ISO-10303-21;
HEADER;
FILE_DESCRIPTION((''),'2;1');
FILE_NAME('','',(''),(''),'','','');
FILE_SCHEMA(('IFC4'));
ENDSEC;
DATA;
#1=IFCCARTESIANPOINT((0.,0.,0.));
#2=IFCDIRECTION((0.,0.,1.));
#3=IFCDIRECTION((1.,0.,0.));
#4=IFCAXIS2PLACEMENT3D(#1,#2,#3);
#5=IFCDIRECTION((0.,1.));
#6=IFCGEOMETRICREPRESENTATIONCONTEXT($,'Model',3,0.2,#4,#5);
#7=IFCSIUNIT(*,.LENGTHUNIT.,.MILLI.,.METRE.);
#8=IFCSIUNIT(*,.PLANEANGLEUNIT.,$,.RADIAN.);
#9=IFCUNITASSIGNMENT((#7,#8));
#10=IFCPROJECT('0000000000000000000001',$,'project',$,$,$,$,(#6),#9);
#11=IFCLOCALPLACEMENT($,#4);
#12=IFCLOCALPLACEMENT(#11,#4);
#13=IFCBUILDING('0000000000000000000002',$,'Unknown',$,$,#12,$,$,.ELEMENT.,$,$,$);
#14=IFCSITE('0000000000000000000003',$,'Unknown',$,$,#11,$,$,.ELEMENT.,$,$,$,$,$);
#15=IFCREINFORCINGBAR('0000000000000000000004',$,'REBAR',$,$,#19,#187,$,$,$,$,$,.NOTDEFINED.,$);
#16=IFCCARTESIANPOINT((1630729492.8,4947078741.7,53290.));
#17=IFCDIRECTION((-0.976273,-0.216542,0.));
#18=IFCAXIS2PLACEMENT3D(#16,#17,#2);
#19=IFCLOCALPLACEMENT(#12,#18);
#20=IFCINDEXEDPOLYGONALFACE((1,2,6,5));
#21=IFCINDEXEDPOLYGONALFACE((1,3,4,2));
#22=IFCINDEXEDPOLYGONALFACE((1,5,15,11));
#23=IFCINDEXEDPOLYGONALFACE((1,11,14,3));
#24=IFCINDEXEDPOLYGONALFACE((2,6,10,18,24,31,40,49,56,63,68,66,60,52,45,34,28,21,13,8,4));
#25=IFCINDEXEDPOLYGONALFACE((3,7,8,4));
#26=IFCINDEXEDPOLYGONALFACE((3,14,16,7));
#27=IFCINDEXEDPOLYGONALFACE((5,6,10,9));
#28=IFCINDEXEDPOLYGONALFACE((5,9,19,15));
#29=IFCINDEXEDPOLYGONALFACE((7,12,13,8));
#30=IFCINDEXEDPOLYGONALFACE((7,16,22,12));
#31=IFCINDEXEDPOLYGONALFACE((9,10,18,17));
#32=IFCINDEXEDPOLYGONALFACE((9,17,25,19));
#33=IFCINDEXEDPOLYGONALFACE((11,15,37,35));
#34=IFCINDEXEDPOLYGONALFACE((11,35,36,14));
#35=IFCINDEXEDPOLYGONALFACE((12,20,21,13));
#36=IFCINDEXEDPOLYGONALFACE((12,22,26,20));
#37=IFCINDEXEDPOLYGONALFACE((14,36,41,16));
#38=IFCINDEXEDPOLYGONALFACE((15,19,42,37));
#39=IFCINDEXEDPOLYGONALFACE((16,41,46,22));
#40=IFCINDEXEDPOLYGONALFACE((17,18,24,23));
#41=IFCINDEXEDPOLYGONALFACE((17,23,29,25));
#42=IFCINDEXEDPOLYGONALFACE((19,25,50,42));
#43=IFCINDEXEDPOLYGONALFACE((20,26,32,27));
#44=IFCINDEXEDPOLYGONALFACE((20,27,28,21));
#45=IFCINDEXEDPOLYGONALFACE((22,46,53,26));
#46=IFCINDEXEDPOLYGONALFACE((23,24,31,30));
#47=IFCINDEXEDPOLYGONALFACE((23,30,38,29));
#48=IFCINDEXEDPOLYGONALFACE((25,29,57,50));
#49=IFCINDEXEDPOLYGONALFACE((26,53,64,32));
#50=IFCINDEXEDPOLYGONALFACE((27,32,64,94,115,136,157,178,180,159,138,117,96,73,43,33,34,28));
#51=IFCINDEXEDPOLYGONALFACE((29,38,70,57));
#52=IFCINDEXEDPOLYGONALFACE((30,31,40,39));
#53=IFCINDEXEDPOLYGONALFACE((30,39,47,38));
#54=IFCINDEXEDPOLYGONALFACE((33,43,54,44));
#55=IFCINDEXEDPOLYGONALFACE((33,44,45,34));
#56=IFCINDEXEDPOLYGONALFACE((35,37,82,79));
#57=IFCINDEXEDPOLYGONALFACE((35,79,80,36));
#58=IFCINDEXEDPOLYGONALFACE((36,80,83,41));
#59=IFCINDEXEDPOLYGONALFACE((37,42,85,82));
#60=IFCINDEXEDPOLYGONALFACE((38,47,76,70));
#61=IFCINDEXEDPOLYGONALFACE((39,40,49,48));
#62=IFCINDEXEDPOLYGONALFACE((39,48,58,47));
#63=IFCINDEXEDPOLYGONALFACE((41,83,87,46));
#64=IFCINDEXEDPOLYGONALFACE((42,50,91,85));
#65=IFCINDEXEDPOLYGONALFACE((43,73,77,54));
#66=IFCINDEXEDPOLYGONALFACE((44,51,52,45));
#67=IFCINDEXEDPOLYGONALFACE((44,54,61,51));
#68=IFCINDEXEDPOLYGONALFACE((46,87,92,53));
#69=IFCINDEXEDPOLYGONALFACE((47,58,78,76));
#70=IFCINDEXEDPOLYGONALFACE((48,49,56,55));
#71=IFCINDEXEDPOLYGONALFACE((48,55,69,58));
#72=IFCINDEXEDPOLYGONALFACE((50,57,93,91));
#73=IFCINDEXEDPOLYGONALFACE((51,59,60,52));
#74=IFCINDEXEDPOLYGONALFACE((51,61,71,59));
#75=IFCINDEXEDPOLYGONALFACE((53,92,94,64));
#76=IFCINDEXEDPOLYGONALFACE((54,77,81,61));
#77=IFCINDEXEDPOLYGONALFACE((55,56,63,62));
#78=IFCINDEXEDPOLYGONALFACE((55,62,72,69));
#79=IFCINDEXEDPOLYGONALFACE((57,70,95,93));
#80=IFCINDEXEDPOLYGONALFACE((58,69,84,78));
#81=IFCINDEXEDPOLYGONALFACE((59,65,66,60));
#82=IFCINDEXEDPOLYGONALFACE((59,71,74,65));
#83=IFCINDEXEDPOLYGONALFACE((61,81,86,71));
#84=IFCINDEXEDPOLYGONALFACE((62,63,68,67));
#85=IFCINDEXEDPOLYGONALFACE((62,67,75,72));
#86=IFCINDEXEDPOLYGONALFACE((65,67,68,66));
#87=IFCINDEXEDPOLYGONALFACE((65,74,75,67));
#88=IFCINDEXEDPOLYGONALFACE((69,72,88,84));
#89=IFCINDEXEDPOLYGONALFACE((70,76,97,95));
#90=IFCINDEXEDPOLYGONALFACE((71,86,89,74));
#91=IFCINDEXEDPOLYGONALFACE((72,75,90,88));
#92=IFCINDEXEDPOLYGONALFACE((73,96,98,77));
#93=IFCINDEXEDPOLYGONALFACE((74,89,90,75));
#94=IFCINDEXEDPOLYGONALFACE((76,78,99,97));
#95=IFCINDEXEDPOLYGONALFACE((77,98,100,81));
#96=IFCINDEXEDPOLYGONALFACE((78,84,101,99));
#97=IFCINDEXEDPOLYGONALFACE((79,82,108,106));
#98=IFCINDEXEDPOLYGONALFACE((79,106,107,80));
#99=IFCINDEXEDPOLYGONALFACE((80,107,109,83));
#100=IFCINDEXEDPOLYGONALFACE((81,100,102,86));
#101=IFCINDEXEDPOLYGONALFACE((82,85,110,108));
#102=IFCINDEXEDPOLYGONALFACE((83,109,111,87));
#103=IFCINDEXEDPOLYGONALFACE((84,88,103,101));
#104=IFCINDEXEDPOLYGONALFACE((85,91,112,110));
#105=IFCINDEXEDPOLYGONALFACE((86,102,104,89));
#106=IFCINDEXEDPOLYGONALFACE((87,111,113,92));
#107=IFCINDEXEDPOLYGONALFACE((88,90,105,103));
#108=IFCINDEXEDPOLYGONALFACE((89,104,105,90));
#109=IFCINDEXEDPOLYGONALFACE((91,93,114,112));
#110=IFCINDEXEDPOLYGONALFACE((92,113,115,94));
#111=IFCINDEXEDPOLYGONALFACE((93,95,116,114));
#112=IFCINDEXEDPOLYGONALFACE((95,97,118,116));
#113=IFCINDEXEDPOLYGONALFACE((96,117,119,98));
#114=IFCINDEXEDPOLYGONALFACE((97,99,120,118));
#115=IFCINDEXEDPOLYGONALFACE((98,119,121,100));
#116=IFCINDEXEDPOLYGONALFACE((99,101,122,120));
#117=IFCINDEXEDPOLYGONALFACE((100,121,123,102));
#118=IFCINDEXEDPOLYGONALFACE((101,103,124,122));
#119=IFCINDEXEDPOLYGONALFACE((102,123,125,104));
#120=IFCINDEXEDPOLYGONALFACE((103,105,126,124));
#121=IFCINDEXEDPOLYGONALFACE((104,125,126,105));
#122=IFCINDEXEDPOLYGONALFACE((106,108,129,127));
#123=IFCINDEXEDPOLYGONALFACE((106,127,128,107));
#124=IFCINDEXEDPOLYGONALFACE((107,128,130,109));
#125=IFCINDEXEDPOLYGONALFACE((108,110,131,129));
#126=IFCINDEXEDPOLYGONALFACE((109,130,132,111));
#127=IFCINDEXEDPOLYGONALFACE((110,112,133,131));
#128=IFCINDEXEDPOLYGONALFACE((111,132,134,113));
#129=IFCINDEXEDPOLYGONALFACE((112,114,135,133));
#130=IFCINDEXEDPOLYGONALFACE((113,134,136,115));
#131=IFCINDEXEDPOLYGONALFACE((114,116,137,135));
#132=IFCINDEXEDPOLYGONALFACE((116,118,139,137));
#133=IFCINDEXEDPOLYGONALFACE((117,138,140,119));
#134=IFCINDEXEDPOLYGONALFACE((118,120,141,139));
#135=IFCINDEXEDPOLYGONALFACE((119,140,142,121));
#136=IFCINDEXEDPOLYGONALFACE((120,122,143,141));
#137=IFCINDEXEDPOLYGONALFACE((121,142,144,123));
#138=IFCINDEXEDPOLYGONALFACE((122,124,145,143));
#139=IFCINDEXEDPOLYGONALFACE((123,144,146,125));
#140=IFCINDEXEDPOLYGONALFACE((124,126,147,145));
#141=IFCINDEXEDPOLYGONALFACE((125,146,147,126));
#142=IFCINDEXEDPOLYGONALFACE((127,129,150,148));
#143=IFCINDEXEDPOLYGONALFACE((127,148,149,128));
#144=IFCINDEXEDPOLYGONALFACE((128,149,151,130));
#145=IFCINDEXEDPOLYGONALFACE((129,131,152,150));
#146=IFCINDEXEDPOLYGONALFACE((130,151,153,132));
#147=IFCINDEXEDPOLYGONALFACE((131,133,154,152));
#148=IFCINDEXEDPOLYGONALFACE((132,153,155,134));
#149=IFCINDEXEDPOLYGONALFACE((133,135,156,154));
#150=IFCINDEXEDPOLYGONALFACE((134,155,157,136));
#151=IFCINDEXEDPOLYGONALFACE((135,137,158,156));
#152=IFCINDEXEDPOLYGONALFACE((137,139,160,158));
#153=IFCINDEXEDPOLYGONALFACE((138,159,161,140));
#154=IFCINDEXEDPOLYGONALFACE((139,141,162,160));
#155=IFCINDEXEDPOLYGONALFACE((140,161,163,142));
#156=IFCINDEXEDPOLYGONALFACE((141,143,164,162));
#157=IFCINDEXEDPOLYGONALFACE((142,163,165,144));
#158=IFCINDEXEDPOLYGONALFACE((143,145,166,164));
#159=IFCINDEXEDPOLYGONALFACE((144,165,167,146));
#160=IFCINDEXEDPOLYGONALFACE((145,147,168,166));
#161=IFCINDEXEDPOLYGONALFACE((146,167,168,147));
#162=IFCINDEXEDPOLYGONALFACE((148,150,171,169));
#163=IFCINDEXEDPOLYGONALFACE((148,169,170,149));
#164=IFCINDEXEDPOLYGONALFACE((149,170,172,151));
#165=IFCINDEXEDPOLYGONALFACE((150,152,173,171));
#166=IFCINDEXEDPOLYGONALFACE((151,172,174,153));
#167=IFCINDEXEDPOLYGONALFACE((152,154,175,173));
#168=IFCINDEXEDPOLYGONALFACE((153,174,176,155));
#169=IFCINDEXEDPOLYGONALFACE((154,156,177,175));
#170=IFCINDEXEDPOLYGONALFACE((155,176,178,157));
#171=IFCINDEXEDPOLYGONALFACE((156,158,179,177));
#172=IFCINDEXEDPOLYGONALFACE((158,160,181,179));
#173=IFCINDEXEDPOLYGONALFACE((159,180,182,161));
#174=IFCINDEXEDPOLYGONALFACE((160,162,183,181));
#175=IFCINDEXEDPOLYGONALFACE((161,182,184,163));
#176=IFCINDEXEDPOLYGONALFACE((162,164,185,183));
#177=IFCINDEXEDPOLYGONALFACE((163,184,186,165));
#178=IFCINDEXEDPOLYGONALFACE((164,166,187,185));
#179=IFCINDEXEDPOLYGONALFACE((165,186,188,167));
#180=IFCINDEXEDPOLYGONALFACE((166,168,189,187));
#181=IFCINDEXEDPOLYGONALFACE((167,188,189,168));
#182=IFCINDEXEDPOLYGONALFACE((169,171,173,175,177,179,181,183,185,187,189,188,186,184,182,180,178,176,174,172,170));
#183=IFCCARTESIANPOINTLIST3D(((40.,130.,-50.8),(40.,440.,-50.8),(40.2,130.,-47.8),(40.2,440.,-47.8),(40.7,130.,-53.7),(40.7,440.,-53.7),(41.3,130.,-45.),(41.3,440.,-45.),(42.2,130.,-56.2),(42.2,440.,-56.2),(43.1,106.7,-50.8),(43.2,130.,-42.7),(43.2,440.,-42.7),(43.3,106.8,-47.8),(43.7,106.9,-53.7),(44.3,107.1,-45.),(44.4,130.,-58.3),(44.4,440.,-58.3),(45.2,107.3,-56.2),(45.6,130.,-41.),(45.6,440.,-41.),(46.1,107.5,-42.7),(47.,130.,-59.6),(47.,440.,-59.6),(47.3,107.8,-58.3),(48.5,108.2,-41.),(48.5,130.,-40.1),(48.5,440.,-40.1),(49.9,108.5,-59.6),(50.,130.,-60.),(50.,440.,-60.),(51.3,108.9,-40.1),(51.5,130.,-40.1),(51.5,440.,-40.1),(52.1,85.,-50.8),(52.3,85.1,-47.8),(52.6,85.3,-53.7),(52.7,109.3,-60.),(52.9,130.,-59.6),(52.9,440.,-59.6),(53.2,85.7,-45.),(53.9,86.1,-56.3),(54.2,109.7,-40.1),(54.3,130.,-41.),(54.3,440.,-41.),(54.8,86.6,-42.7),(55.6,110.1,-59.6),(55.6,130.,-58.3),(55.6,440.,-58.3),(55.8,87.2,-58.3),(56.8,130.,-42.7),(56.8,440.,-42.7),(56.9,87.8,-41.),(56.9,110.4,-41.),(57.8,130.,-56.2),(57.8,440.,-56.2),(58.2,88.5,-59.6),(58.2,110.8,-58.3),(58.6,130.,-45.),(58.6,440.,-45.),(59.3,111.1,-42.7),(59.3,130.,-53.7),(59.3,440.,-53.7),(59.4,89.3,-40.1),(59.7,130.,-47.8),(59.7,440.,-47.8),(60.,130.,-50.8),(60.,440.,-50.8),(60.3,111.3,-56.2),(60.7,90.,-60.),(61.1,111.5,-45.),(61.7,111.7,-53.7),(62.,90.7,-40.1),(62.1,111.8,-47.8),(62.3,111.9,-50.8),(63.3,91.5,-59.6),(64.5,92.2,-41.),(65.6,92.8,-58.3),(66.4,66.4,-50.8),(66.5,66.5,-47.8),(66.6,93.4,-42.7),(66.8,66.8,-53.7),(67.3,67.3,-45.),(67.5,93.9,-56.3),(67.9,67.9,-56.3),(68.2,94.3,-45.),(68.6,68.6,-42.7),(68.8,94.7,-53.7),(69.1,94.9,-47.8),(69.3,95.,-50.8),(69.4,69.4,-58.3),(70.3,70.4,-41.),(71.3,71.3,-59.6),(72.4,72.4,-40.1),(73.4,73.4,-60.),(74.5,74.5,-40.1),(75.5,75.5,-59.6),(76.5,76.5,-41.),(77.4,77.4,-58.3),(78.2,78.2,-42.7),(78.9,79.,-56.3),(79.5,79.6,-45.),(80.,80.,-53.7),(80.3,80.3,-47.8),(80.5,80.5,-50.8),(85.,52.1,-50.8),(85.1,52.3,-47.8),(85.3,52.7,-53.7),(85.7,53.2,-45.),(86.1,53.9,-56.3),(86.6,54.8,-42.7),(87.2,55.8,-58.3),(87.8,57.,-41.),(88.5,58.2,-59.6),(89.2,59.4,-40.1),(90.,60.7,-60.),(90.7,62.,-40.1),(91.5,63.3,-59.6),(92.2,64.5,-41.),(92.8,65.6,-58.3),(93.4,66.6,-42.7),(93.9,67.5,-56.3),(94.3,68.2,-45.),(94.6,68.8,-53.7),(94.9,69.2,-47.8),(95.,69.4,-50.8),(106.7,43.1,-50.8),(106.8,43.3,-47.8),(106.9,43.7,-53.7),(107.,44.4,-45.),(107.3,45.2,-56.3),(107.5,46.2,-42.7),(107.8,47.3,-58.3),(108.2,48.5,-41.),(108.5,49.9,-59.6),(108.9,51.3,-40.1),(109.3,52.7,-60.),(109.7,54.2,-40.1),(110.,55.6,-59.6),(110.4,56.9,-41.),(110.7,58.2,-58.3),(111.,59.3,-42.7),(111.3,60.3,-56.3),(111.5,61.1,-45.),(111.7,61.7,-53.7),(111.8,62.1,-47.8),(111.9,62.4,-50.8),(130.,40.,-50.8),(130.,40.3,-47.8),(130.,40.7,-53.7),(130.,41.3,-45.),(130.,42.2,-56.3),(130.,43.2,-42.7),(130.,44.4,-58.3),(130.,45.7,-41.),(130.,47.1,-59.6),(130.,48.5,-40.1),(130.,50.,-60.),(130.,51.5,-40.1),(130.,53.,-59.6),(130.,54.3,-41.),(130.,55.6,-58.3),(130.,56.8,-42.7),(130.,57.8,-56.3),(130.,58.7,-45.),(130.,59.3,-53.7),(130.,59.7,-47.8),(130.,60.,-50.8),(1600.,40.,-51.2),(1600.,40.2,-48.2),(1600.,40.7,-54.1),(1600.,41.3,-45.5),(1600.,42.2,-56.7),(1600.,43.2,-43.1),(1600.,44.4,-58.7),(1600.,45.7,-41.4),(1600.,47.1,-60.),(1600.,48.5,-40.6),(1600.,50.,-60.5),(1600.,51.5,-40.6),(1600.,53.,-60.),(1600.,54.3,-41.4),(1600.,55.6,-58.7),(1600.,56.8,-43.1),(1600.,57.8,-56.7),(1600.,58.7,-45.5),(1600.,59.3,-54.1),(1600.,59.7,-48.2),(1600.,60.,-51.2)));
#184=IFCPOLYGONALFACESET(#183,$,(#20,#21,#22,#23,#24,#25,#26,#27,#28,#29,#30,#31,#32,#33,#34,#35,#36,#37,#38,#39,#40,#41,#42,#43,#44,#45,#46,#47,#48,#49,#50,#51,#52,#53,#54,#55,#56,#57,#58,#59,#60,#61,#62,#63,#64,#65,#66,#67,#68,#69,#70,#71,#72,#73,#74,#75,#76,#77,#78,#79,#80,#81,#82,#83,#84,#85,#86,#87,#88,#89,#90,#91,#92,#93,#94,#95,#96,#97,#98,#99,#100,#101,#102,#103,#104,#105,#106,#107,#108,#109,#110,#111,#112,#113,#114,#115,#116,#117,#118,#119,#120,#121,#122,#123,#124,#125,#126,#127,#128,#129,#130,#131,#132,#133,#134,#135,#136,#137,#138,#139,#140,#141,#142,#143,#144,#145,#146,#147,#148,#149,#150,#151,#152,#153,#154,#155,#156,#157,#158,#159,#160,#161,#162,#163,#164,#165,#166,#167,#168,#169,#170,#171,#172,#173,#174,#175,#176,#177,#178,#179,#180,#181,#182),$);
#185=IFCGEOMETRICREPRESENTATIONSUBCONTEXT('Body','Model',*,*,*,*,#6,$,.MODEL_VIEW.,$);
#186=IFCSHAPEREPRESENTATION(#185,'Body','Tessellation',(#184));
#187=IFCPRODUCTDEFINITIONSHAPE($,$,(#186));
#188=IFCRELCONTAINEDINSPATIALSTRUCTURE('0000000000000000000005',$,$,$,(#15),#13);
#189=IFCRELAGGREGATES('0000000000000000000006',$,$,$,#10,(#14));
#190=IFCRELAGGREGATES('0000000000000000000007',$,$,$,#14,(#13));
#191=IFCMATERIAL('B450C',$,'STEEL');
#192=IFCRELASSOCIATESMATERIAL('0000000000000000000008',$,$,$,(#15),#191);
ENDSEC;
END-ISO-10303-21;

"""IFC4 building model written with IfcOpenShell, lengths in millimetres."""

from ifc_helpers import new_model, entity, si_unit, direction, frame, origin_with_axes, place, context, subcontext, project, spatial, material, element, save


model = new_model("IFC4")

# Units and contexts
model_context = context("Model", 3, precision=0.2, world=origin_with_axes(), true_north=direction((0.0, 1.0)))
body_context = subcontext(model_context, "Body", "Model", "MODEL_VIEW")
ifc_project = project(units=[si_unit("LENGTHUNIT", "METRE", prefix="MILLI"), si_unit("PLANEANGLEUNIT", "RADIAN")], contexts=[model_context])

# Site, building
site_placement = place(None, origin_with_axes())
site = spatial("IfcSite", under=ifc_project, at=site_placement, Name="Unknown", CompositionType="ELEMENT")
building_placement = place(site_placement, origin_with_axes())
building = spatial("IfcBuilding", under=site, at=building_placement, Name="Unknown", CompositionType="ELEMENT")

# Reinforcing bar
ifc_material = material(Name="B450C", Category="STEEL")
reinforcing_bar_1_placement = place(building_placement, frame((1630729492.8, 4947078741.7, 53290.0), z_axis=(-0.976273, -0.216542, 0.0), x_axis=(0.0, 0.0, 1.0)))
element("IfcReinforcingBar", 1, at=reinforcing_bar_1_placement, inside=building, material=ifc_material, Name="REBAR", PredefinedType="NOTDEFINED", context=body_context, shape_type="AdvancedSweptSolid", body=[
    entity("IfcSweptDiskSolid", entity("IfcIndexedPolyCurve", entity("IfcCartesianPointList3D", [[50.0, 440.0, -50.0], [50.0, 130.0, -50.0], [73.4, 73.4, -50.0], [130.0, 50.0, -50.0], [1600.0, 50.0, -50.5]]), [entity("IfcLineIndex", [1, 2]), entity("IfcArcIndex", [2, 3, 4]), entity("IfcLineIndex", [4, 5])]), 10.0),
])

save(model, "model.ifc")
